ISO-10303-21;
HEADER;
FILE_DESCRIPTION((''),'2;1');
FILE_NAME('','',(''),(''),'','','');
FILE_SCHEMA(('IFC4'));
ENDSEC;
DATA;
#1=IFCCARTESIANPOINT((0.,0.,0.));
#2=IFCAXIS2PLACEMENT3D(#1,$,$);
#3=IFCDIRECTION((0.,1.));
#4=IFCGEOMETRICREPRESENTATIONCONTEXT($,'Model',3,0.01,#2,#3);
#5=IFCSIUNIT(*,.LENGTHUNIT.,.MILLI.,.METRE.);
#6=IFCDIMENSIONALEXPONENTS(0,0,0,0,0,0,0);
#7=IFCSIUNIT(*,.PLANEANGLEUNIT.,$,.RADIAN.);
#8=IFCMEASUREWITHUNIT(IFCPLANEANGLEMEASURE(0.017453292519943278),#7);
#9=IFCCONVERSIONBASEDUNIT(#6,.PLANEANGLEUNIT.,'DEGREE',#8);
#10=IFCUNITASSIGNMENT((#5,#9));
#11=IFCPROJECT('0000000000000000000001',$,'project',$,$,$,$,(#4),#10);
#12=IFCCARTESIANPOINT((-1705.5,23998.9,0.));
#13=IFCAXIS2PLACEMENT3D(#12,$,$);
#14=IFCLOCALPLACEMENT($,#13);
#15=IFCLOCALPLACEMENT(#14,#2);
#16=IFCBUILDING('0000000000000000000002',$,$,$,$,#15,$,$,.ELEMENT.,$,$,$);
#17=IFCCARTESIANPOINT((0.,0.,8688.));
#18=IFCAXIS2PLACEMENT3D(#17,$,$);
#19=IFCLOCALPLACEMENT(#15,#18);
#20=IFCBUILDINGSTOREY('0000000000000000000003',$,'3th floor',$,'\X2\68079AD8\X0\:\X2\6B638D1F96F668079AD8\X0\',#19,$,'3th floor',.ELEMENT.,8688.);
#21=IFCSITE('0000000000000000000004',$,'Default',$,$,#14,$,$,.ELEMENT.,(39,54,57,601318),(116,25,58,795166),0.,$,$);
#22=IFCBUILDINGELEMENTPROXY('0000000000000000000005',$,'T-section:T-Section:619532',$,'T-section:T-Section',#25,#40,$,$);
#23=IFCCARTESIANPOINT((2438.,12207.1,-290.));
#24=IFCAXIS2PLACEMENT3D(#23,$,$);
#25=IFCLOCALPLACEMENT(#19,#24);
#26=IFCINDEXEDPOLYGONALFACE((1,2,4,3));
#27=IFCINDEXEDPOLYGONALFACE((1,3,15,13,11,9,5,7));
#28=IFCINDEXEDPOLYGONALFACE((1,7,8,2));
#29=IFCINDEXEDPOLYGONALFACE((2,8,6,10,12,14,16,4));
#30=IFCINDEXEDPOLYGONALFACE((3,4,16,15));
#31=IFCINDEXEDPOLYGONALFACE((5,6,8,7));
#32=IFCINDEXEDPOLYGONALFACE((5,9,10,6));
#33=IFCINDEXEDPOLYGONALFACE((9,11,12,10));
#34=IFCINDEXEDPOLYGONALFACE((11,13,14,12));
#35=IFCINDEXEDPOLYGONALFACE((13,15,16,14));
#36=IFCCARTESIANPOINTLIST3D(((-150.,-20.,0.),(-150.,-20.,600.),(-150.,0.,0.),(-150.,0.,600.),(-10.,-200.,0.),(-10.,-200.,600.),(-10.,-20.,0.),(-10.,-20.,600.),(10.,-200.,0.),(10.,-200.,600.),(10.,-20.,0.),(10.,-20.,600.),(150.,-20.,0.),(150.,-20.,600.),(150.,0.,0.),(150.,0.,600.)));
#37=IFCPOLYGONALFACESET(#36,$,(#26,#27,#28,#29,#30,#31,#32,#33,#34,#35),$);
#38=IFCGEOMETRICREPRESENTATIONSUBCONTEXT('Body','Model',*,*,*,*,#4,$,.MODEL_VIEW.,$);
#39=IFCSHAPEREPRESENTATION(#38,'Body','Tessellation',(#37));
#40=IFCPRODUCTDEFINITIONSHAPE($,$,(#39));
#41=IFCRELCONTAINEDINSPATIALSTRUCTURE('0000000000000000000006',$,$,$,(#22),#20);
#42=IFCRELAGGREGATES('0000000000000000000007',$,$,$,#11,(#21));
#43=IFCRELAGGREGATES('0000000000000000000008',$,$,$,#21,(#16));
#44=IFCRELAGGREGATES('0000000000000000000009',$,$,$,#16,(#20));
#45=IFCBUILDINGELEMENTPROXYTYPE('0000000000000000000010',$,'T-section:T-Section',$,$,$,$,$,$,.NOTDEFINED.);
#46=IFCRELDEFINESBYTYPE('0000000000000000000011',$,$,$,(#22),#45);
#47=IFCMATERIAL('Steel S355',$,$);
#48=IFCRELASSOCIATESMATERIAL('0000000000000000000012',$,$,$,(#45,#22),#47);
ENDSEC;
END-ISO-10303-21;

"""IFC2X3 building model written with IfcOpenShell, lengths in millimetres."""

from ifc_helpers import new_model, entity, si_unit, converted_unit, direction, frame, origin, place, context, subcontext, project, spatial, polyline, outline, extrude, source, transform, mapped, material, type_object, type_shapes, element, save


model = new_model("IFC2X3")

# Units and contexts
model_context = context("Model", 3, precision=0.01, world=origin(), true_north=direction((0.0, 1.0)))
body_context = subcontext(model_context, "Body", "Model", "MODEL_VIEW")
ifc_project = project(units=[si_unit("LENGTHUNIT", "METRE", prefix="MILLI"), converted_unit("PLANEANGLEUNIT", "DEGREE", entity("IfcPlaneAngleMeasure", 0.017453292519943278), si_unit("PLANEANGLEUNIT", "RADIAN"), dimensions=[0, 0, 0, 0, 0, 0, 0])], contexts=[model_context])

# Site, building, storey
site_placement = place(None, frame((-1705.5, 23998.9, 0.0)))
site = spatial("IfcSite", under=ifc_project, at=site_placement, Name="Default", CompositionType="ELEMENT", RefLatitude=(39, 54, 57, 601318), RefLongitude=(116, 25, 58, 795166), RefElevation=0.0)
building_placement = place(site_placement, origin())
building = spatial("IfcBuilding", under=site, at=building_placement, CompositionType="ELEMENT")
storey_placement = place(building_placement, frame((0.0, 0.0, 8688.0)))
storey = spatial("IfcBuildingStorey", under=building, at=storey_placement, Name="3th floor", ObjectType="标高:正负零标高", LongName="3th floor", CompositionType="ELEMENT", Elevation=8688.0)

# Shared definitions
ifc_material_1 = material(Name="Steel S355")

# Building element proxy
building_element_proxy_type_1 = type_object("IfcBuildingElementProxyType", Name="T-section:T-Section", PredefinedType="NOTDEFINED", material=ifc_material_1)
shared_shape_1 = source(origin(), body_context, "Body", "SweptSolid", [
    extrude(outline(polyline([(-10.0, -140.0), (10.0, -140.0), (10.0, 40.0), (150.0, 40.0), (150.0, 60.0), (-150.0, 60.0), (-150.0, 40.0), (-10.0, 40.0), (-10.0, -140.0)])), frame((0.0, -60.0, 0.0)), (0.0, 0.0, 1.0), 600.0),
])
type_shapes(building_element_proxy_type_1, [shared_shape_1])
proxy_1_placement = place(storey_placement, frame((2438.0, 12207.1, -290.0)))
element("IfcBuildingElementProxy", 1, at=proxy_1_placement, inside=storey, type_object=building_element_proxy_type_1, material=ifc_material_1, Name="T-section:T-Section:619532", ObjectType="T-section:T-Section", context=body_context, shape_type="MappedRepresentation", body=[
    mapped(shared_shape_1, transform((0.0, 0.0, 0.0), scale=1.0)),
])

save(model, "model.ifc")
